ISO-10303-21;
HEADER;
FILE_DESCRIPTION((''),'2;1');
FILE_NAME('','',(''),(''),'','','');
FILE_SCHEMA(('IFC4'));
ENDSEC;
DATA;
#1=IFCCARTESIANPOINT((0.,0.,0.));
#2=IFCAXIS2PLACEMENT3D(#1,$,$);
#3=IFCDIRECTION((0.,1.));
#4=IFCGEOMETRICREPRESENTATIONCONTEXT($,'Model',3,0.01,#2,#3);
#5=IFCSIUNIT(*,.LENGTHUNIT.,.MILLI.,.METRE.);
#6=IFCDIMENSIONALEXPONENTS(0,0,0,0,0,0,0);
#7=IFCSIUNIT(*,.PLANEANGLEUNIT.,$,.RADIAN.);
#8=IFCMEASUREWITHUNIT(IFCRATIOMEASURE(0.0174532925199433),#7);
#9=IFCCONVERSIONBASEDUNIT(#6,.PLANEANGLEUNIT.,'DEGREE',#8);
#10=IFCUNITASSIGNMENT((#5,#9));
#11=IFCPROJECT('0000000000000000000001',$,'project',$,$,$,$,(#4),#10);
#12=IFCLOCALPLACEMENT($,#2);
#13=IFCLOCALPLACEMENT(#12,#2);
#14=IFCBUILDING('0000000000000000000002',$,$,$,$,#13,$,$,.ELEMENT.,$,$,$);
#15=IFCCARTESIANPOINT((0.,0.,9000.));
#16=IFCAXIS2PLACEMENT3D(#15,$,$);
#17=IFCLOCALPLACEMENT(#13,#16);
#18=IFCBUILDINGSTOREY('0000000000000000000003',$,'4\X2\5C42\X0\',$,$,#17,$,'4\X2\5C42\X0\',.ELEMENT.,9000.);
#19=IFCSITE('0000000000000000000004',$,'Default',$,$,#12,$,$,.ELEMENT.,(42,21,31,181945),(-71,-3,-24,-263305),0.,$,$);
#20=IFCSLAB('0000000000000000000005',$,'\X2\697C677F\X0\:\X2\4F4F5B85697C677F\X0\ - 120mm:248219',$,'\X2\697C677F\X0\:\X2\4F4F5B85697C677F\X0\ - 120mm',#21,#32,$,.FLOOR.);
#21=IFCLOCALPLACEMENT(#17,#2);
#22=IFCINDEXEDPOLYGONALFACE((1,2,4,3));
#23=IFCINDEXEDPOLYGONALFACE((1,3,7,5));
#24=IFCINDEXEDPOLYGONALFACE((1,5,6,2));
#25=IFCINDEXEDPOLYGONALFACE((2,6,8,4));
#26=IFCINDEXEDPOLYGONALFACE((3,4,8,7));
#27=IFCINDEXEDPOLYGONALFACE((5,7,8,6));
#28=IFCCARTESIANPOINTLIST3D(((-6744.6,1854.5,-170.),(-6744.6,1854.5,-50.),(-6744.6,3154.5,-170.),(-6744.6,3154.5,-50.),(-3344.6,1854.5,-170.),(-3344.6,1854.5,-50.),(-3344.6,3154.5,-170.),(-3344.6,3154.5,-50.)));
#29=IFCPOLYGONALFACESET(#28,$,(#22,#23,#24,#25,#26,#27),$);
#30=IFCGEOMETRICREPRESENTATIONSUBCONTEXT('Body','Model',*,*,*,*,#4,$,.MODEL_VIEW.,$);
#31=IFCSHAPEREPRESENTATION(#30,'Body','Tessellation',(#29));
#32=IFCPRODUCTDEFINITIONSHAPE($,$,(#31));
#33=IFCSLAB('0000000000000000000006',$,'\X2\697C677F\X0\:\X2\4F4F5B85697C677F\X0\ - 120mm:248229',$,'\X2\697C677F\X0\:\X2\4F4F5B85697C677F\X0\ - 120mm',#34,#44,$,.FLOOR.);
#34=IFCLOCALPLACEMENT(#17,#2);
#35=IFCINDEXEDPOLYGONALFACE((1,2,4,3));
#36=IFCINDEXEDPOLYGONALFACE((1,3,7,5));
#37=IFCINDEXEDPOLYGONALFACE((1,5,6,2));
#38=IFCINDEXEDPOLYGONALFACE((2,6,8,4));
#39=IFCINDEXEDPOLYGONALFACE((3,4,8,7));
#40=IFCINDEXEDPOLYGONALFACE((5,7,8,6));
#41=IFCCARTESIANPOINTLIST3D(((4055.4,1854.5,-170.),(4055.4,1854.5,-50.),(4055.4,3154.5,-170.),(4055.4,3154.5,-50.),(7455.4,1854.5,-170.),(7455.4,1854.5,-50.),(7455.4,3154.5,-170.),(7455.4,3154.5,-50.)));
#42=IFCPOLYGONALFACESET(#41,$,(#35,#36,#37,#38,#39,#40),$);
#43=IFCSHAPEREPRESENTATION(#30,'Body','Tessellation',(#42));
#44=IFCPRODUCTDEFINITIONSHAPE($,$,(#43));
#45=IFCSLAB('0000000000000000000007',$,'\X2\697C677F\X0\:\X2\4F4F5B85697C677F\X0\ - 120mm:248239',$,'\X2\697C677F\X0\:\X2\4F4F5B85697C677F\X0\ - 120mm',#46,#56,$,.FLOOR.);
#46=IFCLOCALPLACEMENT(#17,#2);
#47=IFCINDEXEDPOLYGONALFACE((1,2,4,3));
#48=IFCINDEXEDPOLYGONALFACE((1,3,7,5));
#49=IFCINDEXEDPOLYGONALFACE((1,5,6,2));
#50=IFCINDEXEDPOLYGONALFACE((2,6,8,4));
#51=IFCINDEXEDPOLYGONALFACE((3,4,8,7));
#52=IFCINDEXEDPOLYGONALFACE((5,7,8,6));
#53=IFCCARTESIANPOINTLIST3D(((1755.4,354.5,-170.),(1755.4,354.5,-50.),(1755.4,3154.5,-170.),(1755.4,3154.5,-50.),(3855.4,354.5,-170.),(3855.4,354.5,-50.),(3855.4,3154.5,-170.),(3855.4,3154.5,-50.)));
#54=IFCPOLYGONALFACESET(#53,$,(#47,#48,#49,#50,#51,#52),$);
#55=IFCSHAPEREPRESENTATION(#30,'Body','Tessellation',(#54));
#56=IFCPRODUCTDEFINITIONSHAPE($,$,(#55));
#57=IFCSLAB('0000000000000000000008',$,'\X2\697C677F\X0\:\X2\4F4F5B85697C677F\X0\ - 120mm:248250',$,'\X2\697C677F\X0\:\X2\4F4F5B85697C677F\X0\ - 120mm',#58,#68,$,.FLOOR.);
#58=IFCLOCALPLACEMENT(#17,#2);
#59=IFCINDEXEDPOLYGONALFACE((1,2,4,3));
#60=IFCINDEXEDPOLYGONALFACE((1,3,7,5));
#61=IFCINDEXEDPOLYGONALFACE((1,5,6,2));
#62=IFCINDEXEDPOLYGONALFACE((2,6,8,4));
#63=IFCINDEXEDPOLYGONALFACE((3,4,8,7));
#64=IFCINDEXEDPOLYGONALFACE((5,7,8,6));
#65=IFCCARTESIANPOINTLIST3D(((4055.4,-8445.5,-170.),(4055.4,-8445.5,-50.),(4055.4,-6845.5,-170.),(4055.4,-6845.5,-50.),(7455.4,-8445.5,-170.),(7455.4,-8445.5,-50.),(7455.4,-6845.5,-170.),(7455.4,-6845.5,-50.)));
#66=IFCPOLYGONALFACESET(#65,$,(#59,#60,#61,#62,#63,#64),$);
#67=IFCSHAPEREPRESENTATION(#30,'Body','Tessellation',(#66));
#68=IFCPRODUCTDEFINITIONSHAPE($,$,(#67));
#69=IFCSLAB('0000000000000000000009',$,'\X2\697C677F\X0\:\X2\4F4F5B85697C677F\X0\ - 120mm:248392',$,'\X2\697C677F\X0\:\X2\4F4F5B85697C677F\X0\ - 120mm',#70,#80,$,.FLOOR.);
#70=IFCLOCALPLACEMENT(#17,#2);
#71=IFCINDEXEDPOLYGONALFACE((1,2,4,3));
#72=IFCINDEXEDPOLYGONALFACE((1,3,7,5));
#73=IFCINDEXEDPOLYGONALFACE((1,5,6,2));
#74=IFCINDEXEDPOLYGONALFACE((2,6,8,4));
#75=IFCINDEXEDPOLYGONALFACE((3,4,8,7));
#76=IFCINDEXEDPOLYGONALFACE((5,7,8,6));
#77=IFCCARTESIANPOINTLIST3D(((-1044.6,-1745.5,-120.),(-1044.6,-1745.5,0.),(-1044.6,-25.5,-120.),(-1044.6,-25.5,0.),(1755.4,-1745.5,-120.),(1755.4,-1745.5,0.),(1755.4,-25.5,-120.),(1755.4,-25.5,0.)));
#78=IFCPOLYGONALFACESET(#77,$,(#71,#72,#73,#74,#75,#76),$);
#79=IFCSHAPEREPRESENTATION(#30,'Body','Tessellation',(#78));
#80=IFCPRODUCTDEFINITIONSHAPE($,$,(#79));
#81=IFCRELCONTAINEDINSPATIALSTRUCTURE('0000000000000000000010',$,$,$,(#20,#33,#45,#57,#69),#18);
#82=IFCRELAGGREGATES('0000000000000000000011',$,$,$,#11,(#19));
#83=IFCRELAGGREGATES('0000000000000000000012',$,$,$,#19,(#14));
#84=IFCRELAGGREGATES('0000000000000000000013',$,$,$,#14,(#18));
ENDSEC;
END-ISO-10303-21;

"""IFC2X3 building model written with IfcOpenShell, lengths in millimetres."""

from ifc_helpers import new_model, entity, si_unit, converted_unit, direction, frame, frame_2d, origin, origin_2d_with_axis, place, context, subcontext, project, spatial, rectangle, extrude, element, save


model = new_model("IFC2X3")

# Units and contexts
model_context = context("Model", 3, precision=0.01, world=origin(), true_north=direction((0.0, 1.0)))
body_context = subcontext(model_context, "Body", "Model", "MODEL_VIEW")
ifc_project = project(units=[si_unit("LENGTHUNIT", "METRE", prefix="MILLI"), converted_unit("PLANEANGLEUNIT", "DEGREE", entity("IfcRatioMeasure", 0.0174532925199433), si_unit("PLANEANGLEUNIT", "RADIAN"), dimensions=[0, 0, 0, 0, 0, 0, 0])], contexts=[model_context])

# Site, building, storey
site_placement = place(None, origin())
site = spatial("IfcSite", under=ifc_project, at=site_placement, Name="Default", CompositionType="ELEMENT", RefLatitude=(42, 21, 31, 181945), RefLongitude=(-71, -3, -24, -263305), RefElevation=0.0)
building_placement = place(site_placement, origin())
building = spatial("IfcBuilding", under=site, at=building_placement, CompositionType="ELEMENT")
storey_placement = place(building_placement, frame((0.0, 0.0, 9000.0)))
storey = spatial("IfcBuildingStorey", under=building, at=storey_placement, Name="4层", LongName="4层", CompositionType="ELEMENT", Elevation=9000.0)

# Slabs
slab_1_placement = place(storey_placement, origin())
element("IfcSlab", 1, at=slab_1_placement, inside=storey, Name="楼板:住宅楼板 - 120mm:248219", ObjectType="楼板:住宅楼板 - 120mm", PredefinedType="FLOOR", context=body_context, shape_type="SweptSolid", body=[
    extrude(rectangle(XDim=1300.0, YDim=3400.0, at=frame_2d((0.0, 0.0), x_axis=(1.0, 0.0))), frame((-5044.6, 2504.5, -50.0), z_axis=(0.0, 0.0, -1.0), x_axis=(0.0, 1.0, 0.0)), (0.0, 0.0, 1.0), 120.0),
])
slab_2_placement = place(storey_placement, origin())
element("IfcSlab", 2, at=slab_2_placement, inside=storey, Name="楼板:住宅楼板 - 120mm:248229", ObjectType="楼板:住宅楼板 - 120mm", PredefinedType="FLOOR", context=body_context, shape_type="SweptSolid", body=[
    extrude(rectangle(XDim=1300.0, YDim=3400.0, at=frame_2d((0.0, 0.0), x_axis=(1.0, 0.0))), frame((5755.4, 2504.5, -50.0), z_axis=(0.0, 0.0, -1.0), x_axis=(0.0, 1.0, 0.0)), (0.0, 0.0, 1.0), 120.0),
])
slab_3_placement = place(storey_placement, origin())
element("IfcSlab", 3, at=slab_3_placement, inside=storey, Name="楼板:住宅楼板 - 120mm:248239", ObjectType="楼板:住宅楼板 - 120mm", PredefinedType="FLOOR", context=body_context, shape_type="SweptSolid", body=[
    extrude(rectangle(XDim=2800.0, YDim=2100.0, at=origin_2d_with_axis()), frame((2805.4, 1754.5, -50.0), z_axis=(0.0, 0.0, -1.0), x_axis=(0.0, 1.0, 0.0)), (0.0, 0.0, 1.0), 120.0),
])
slab_4_placement = place(storey_placement, origin())
element("IfcSlab", 4, at=slab_4_placement, inside=storey, Name="楼板:住宅楼板 - 120mm:248250", ObjectType="楼板:住宅楼板 - 120mm", PredefinedType="FLOOR", context=body_context, shape_type="SweptSolid", body=[
    extrude(rectangle(XDim=1600.0, YDim=3400.0, at=frame_2d((0.0, 0.0), x_axis=(1.0, 0.0))), frame((5755.4, -7645.5, -50.0), z_axis=(0.0, 0.0, -1.0), x_axis=(0.0, 1.0, 0.0)), (0.0, 0.0, 1.0), 120.0),
])
slab_5_placement = place(storey_placement, origin())
element("IfcSlab", 5, at=slab_5_placement, inside=storey, Name="楼板:住宅楼板 - 120mm:248392", ObjectType="楼板:住宅楼板 - 120mm", PredefinedType="FLOOR", context=body_context, shape_type="SweptSolid", body=[
    extrude(rectangle(XDim=1720.0, YDim=2800.0, at=origin_2d_with_axis()), frame((355.4, -885.5, 0.0), z_axis=(0.0, 0.0, -1.0), x_axis=(0.0, 1.0, 0.0)), (0.0, 0.0, 1.0), 120.0),
])

save(model, "model.ifc")
